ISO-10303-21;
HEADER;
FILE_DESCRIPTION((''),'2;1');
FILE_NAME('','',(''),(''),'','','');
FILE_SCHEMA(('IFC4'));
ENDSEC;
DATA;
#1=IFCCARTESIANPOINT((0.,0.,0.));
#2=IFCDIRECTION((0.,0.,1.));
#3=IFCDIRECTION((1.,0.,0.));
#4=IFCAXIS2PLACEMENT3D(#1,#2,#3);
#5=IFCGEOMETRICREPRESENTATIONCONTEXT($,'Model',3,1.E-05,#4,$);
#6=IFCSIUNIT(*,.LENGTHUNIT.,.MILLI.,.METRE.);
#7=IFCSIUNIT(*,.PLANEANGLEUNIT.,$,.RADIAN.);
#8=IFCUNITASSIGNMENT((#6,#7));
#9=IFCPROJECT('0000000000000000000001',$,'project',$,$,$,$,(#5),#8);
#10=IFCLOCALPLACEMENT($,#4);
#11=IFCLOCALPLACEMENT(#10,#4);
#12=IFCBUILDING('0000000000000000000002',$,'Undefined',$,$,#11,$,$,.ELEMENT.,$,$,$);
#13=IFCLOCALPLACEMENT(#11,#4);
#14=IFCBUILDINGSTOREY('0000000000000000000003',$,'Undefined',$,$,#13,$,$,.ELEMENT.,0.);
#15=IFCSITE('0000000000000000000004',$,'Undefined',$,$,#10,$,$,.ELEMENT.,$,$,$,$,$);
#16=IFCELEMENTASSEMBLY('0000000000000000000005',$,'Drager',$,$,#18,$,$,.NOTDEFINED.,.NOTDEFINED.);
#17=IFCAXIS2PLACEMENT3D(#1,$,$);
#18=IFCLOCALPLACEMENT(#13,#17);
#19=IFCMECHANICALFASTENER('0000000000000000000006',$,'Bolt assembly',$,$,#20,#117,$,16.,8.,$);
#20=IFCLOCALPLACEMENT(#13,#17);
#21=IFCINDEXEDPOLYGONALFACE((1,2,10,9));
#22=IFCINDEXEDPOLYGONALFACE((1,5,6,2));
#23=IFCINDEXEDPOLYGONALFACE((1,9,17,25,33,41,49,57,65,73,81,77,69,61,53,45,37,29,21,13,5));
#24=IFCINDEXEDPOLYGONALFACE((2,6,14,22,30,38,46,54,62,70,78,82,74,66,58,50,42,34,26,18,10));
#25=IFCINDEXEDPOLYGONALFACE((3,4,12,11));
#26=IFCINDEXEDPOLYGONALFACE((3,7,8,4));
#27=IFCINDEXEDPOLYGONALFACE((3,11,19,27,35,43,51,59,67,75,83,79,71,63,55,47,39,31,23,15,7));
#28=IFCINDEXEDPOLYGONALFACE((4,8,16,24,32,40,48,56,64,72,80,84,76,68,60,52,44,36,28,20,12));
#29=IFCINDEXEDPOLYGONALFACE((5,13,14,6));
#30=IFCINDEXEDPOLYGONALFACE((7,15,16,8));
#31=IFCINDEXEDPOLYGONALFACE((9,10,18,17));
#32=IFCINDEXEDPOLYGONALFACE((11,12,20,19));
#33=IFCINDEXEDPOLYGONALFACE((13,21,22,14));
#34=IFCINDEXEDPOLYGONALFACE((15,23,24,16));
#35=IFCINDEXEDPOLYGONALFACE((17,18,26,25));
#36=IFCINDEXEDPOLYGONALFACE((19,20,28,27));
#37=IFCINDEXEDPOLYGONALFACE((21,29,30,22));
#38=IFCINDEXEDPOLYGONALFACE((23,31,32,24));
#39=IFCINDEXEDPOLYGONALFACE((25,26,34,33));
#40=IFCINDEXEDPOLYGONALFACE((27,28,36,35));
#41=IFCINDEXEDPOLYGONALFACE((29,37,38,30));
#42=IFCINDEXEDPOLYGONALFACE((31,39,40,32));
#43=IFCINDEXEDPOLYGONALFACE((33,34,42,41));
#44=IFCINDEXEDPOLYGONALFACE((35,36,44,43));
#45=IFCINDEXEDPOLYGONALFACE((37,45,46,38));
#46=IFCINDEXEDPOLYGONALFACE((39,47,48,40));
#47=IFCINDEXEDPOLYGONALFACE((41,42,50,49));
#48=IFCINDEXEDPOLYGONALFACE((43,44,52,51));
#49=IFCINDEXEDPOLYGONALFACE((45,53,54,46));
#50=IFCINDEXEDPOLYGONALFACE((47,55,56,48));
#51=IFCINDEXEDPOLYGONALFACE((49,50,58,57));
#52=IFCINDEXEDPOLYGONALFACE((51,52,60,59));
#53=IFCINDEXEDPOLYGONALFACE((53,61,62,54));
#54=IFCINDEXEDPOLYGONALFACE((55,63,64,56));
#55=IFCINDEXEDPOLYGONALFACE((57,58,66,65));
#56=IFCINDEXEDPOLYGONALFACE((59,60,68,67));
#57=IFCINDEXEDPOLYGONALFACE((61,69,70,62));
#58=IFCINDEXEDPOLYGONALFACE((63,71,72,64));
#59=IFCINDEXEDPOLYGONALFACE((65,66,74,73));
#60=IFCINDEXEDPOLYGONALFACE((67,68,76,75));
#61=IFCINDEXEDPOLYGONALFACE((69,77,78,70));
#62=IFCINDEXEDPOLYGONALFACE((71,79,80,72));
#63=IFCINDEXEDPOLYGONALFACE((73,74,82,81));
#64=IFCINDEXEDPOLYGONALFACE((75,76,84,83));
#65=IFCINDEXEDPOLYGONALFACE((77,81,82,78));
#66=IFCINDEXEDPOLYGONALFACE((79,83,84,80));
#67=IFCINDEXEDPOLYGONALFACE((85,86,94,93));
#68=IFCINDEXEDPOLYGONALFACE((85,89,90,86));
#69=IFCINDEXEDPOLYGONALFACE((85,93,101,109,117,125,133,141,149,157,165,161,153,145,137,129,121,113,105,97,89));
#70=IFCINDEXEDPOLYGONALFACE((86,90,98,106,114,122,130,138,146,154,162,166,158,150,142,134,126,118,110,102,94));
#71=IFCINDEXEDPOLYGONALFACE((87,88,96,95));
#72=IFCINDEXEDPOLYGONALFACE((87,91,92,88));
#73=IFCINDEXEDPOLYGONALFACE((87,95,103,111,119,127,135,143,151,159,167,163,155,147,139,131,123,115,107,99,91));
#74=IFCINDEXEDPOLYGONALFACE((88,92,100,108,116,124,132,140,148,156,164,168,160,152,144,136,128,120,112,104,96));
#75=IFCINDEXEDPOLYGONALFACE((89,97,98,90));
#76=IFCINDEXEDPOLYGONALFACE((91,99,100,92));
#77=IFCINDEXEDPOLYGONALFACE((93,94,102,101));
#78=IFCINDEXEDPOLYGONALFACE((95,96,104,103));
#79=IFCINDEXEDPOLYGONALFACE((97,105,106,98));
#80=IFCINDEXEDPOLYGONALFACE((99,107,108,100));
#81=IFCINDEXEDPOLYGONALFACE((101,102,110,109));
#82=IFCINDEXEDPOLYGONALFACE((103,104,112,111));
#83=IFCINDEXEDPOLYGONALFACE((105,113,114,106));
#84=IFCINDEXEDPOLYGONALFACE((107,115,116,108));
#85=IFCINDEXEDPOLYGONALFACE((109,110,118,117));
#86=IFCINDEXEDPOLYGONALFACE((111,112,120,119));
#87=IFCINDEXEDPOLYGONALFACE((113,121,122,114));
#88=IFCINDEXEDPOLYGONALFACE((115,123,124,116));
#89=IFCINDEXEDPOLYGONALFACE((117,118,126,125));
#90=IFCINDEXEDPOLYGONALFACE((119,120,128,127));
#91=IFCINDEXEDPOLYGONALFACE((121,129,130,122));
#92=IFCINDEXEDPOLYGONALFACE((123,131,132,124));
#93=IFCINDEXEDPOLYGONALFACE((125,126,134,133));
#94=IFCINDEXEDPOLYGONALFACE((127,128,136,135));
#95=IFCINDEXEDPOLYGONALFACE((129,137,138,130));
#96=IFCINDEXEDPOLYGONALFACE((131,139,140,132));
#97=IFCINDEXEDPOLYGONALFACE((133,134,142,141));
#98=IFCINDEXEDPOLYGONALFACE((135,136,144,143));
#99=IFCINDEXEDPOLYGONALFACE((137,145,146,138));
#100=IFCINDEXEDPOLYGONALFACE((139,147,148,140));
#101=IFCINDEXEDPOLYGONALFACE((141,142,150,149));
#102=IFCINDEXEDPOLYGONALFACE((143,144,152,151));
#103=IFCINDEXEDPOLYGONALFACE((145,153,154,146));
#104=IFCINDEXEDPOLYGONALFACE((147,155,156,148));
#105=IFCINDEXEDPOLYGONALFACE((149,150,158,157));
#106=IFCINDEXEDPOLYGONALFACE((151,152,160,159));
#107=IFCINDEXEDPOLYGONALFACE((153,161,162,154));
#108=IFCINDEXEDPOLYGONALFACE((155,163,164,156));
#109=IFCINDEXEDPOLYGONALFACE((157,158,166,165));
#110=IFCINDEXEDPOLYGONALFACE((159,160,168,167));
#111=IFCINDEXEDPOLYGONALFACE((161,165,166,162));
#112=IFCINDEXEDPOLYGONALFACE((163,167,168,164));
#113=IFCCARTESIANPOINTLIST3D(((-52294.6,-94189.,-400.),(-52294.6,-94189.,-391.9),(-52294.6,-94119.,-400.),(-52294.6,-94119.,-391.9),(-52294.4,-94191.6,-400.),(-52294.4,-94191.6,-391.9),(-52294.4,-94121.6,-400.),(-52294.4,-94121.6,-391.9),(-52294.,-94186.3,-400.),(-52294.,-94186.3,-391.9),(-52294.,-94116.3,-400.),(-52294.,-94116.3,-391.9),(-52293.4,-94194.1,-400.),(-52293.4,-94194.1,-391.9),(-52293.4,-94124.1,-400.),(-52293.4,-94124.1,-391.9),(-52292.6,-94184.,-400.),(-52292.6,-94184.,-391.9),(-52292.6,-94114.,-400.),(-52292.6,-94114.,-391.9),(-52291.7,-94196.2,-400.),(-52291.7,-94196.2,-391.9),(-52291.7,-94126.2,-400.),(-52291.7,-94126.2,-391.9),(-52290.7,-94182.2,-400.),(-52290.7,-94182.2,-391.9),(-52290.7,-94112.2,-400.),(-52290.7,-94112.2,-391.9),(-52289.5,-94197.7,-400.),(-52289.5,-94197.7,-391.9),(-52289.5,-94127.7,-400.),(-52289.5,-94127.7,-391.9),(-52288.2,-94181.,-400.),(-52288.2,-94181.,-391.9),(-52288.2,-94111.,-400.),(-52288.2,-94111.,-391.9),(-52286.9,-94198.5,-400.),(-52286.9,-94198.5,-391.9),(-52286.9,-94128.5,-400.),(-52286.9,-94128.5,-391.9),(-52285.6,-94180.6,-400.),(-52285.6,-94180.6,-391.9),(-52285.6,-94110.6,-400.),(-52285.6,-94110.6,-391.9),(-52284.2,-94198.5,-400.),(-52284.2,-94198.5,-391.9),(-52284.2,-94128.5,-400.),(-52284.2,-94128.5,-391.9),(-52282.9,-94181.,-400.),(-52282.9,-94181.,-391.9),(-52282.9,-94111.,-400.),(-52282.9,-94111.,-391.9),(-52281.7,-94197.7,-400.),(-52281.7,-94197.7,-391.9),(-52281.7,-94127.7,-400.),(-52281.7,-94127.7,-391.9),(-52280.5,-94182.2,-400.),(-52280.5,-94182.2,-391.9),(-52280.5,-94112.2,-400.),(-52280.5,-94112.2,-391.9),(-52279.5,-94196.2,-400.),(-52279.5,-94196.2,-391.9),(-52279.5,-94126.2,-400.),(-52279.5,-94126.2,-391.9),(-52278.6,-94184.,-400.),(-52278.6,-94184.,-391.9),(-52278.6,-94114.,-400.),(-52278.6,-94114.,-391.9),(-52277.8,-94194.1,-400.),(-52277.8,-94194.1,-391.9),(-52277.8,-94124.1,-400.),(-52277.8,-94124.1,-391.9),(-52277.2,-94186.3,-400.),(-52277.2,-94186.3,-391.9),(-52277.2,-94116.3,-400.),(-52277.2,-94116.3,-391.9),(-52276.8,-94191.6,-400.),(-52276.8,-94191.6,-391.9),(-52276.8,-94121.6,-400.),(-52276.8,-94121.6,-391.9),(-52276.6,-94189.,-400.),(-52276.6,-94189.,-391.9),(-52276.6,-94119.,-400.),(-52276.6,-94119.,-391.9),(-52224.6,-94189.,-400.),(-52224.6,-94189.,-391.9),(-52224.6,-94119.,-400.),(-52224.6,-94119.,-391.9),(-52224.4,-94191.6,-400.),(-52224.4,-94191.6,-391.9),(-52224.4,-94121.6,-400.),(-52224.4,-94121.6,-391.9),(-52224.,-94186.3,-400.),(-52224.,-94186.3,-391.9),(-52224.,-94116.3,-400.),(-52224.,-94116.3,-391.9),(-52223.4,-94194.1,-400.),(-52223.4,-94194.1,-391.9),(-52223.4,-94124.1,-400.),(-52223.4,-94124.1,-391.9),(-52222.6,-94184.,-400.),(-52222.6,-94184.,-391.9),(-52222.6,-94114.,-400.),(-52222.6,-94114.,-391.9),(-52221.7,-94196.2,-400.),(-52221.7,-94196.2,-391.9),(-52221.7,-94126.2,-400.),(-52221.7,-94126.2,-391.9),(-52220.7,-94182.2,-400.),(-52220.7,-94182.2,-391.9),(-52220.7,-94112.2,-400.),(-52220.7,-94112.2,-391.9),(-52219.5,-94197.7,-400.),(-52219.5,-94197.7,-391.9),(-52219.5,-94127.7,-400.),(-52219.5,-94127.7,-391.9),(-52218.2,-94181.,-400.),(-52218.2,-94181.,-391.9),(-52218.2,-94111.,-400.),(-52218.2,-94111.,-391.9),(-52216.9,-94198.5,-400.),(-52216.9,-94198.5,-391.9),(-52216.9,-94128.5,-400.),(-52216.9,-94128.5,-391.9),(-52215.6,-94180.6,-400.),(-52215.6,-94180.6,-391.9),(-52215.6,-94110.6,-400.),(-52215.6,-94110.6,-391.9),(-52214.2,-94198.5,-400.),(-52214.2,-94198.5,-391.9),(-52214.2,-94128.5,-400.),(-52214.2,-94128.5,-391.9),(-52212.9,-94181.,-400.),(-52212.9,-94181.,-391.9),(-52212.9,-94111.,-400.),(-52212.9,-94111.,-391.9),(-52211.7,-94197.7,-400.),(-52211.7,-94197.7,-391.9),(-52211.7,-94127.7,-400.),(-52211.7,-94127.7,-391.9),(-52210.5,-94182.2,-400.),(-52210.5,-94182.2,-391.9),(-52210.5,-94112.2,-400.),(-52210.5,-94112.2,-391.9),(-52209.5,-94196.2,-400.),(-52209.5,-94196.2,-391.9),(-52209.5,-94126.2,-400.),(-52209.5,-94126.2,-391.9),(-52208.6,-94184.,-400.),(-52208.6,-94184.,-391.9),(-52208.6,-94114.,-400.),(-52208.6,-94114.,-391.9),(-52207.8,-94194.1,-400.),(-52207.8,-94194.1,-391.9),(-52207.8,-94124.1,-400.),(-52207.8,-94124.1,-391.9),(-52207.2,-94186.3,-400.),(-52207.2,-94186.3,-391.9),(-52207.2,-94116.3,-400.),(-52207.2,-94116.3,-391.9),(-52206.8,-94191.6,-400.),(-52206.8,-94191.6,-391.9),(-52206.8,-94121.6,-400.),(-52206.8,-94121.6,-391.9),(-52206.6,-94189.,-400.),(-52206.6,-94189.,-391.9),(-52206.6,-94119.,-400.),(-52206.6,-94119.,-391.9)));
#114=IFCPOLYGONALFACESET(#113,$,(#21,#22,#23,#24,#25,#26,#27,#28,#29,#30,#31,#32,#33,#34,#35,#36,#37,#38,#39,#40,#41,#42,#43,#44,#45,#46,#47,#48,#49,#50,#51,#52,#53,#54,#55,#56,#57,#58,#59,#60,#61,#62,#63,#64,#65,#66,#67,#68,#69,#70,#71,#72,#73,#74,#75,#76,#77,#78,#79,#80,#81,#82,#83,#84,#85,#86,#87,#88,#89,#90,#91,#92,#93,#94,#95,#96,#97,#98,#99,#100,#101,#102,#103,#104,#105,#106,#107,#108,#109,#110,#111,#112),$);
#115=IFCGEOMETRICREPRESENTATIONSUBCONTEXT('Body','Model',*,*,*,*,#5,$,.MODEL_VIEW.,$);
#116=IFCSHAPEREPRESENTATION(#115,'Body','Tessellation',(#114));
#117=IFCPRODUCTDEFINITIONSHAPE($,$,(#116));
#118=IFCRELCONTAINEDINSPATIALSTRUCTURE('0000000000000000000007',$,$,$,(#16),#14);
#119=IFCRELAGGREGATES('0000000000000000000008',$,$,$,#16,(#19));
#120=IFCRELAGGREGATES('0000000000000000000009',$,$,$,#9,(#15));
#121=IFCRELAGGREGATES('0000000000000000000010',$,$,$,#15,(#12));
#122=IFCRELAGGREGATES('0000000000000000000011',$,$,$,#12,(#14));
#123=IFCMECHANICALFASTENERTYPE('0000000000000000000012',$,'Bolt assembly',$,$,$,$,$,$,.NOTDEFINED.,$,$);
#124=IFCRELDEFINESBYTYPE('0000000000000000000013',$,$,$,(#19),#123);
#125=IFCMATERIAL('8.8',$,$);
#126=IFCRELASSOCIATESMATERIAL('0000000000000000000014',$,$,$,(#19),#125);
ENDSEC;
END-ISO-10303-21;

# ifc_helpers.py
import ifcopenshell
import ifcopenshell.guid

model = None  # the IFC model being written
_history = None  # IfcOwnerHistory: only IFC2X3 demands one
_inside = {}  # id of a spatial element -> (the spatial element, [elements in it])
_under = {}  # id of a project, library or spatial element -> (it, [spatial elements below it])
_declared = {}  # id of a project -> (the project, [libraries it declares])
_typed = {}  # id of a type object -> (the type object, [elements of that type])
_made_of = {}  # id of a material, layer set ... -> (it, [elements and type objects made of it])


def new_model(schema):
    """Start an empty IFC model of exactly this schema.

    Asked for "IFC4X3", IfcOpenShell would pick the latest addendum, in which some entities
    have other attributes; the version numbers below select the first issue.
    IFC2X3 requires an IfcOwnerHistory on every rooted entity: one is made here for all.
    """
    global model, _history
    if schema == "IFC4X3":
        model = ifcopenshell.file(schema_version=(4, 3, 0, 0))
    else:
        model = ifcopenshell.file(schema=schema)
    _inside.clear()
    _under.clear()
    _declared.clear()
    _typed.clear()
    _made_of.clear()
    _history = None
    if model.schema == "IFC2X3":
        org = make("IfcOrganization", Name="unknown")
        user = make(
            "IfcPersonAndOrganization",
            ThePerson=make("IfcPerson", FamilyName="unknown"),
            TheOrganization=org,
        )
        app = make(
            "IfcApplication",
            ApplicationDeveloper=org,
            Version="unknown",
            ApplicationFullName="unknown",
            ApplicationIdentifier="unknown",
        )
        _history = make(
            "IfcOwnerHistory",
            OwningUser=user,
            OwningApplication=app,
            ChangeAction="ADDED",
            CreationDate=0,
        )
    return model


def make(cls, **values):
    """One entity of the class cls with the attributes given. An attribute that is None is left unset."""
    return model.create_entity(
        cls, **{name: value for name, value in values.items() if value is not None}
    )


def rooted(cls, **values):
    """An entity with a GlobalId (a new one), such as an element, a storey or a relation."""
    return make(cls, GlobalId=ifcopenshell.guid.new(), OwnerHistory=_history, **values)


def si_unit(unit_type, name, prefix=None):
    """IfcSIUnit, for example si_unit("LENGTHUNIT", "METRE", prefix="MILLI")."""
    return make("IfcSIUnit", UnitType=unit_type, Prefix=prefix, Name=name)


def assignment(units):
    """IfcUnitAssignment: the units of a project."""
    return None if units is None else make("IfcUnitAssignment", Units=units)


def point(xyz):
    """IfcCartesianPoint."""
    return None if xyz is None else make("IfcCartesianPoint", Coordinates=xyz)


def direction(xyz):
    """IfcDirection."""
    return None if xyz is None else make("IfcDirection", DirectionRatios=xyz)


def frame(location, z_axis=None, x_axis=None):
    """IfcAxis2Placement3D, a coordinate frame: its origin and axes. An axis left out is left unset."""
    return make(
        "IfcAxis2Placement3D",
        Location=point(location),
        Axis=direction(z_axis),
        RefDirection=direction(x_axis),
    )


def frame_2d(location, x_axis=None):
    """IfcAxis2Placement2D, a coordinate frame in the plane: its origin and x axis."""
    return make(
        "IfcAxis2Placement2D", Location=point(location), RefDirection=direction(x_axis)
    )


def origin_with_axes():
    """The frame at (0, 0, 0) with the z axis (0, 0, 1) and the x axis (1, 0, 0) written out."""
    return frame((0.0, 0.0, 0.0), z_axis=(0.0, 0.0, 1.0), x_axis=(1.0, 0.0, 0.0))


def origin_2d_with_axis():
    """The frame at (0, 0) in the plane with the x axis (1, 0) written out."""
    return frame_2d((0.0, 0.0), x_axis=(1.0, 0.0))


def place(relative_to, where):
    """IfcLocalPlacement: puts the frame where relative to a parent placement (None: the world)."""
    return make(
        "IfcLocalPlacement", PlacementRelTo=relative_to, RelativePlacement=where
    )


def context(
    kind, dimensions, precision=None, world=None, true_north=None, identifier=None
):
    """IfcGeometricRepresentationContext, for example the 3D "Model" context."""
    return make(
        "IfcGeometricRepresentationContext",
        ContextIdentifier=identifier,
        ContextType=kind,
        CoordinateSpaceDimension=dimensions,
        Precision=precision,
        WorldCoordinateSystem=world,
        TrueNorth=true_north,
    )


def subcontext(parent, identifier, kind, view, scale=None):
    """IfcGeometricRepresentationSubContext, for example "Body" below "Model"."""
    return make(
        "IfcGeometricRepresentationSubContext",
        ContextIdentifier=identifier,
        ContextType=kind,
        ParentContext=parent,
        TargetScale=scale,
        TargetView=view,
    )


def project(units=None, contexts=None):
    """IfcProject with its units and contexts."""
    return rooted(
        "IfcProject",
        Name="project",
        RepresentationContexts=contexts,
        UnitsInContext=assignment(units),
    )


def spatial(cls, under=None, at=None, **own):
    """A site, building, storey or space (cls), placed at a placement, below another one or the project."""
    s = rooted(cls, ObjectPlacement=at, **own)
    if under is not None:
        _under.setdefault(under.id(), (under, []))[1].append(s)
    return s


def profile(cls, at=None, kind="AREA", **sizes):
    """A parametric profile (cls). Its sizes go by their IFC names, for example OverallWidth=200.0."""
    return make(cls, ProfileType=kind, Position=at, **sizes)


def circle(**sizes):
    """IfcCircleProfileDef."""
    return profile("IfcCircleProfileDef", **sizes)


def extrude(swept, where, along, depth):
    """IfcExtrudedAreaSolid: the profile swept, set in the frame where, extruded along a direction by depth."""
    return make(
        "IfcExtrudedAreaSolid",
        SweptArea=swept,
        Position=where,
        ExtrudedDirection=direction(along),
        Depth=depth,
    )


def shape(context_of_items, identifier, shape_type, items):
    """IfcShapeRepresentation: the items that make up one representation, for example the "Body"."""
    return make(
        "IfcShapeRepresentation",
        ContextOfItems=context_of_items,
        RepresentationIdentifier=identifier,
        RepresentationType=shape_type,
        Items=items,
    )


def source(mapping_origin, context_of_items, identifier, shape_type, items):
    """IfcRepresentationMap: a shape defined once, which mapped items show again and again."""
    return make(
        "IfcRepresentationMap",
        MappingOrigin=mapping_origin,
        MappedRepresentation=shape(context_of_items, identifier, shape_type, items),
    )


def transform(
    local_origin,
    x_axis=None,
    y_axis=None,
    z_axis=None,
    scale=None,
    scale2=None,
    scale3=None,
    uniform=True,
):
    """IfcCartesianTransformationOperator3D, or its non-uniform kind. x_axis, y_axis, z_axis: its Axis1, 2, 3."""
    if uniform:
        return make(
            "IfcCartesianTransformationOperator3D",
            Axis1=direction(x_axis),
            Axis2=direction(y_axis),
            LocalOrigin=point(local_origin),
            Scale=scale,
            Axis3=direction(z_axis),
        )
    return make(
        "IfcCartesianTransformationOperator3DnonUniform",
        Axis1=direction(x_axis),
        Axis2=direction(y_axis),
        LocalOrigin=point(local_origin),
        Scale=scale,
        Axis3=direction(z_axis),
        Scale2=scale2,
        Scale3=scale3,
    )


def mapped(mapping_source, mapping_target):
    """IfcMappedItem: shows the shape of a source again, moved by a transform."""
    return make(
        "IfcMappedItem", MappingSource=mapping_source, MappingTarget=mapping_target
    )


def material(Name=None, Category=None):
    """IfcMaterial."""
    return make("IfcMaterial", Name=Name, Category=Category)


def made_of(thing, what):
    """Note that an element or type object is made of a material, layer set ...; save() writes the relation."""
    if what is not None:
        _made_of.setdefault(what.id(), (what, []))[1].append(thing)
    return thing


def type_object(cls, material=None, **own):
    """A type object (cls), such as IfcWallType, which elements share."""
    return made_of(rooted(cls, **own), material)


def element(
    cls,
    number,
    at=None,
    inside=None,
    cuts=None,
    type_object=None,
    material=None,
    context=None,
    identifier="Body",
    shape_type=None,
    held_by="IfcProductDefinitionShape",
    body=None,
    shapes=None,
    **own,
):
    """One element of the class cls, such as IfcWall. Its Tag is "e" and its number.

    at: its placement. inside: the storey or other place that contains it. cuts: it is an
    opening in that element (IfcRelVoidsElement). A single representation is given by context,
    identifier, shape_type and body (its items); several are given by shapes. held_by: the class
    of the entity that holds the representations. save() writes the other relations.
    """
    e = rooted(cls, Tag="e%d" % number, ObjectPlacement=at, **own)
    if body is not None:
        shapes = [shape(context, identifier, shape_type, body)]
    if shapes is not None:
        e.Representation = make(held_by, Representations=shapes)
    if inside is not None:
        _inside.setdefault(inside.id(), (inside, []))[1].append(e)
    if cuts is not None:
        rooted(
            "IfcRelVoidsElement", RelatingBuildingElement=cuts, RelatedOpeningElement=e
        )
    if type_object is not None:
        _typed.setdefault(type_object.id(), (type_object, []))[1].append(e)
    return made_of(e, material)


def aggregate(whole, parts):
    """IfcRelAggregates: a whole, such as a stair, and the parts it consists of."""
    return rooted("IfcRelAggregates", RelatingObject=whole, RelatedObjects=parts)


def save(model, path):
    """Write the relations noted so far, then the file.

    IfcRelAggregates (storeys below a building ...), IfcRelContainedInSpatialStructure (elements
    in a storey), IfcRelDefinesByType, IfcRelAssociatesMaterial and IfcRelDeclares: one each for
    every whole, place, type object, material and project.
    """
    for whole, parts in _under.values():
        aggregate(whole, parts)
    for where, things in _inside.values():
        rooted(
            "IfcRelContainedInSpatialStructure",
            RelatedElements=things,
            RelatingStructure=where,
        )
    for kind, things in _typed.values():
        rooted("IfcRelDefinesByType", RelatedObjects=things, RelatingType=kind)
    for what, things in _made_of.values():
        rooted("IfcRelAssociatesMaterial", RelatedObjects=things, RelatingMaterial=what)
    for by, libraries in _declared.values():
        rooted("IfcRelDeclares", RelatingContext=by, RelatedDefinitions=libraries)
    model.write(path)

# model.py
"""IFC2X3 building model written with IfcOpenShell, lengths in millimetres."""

from ifc_helpers import new_model, si_unit, frame, origin_with_axes, origin_2d_with_axis, place, context, subcontext, project, spatial, circle, extrude, source, transform, mapped, material, type_object, element, aggregate, save


model = new_model("IFC2X3")

# Units and contexts
model_context = context("Model", 3, precision=1e-05, world=origin_with_axes())
body_context = subcontext(model_context, "Body", "Model", "MODEL_VIEW")
ifc_project = project(units=[si_unit("LENGTHUNIT", "METRE", prefix="MILLI"), si_unit("PLANEANGLEUNIT", "RADIAN")], contexts=[model_context])

# Site, building, storey
site_placement = place(None, origin_with_axes())
site = spatial("IfcSite", under=ifc_project, at=site_placement, Name="Undefined", CompositionType="ELEMENT")
building_placement = place(site_placement, origin_with_axes())
building = spatial("IfcBuilding", under=site, at=building_placement, Name="Undefined", CompositionType="ELEMENT")
storey_placement = place(building_placement, origin_with_axes())
storey = spatial("IfcBuildingStorey", under=building, at=storey_placement, Name="Undefined", CompositionType="ELEMENT", Elevation=0.0)

# Element assembly, mechanical fastener
assembly_1_placement = place(storey_placement, origin_with_axes())
assembly_1 = element("IfcElementAssembly", 1, at=assembly_1_placement, inside=storey, Name="Drager", AssemblyPlace="NOTDEFINED", PredefinedType="NOTDEFINED")
ifc_material_1 = material(Name="8.8")
mechanical_fastener_type = type_object("IfcMechanicalFastenerType", Name="Bolt assembly")
shared_shape_1 = source(origin_with_axes(), body_context, "Body", "SweptSolid", [
    extrude(circle(Radius=9.0, at=origin_2d_with_axis()), frame((0.0, -8.0, 0.0), z_axis=(0.0, 1.0, 0.0), x_axis=(1.0, 0.0, 0.0)), (0.0, 0.0, 1.0), 8.1),
])
mechanical_fastener_1_placement = place(assembly_1_placement, frame((-52250.6, -94189.6, -392.0), z_axis=(1.0, 0.0, 0.0), x_axis=(0.0, 1.0, 0.0)))
mechanical_fastener_1 = element("IfcMechanicalFastener", 2, at=mechanical_fastener_1_placement, type_object=mechanical_fastener_type, material=ifc_material_1, Name="Bolt assembly", NominalDiameter=16.0, NominalLength=8.0, context=body_context, shape_type="MappedRepresentation", body=[
    mapped(shared_shape_1, transform((0.0, 0.0, -35.0))),
    mapped(shared_shape_1, transform((70.0, 0.0, -35.0))),
    mapped(shared_shape_1, transform((0.0, 0.0, 35.0))),
    mapped(shared_shape_1, transform((70.0, 0.0, 35.0))),
])
aggregate(assembly_1, [mechanical_fastener_1])

save(model, "model.ifc")
